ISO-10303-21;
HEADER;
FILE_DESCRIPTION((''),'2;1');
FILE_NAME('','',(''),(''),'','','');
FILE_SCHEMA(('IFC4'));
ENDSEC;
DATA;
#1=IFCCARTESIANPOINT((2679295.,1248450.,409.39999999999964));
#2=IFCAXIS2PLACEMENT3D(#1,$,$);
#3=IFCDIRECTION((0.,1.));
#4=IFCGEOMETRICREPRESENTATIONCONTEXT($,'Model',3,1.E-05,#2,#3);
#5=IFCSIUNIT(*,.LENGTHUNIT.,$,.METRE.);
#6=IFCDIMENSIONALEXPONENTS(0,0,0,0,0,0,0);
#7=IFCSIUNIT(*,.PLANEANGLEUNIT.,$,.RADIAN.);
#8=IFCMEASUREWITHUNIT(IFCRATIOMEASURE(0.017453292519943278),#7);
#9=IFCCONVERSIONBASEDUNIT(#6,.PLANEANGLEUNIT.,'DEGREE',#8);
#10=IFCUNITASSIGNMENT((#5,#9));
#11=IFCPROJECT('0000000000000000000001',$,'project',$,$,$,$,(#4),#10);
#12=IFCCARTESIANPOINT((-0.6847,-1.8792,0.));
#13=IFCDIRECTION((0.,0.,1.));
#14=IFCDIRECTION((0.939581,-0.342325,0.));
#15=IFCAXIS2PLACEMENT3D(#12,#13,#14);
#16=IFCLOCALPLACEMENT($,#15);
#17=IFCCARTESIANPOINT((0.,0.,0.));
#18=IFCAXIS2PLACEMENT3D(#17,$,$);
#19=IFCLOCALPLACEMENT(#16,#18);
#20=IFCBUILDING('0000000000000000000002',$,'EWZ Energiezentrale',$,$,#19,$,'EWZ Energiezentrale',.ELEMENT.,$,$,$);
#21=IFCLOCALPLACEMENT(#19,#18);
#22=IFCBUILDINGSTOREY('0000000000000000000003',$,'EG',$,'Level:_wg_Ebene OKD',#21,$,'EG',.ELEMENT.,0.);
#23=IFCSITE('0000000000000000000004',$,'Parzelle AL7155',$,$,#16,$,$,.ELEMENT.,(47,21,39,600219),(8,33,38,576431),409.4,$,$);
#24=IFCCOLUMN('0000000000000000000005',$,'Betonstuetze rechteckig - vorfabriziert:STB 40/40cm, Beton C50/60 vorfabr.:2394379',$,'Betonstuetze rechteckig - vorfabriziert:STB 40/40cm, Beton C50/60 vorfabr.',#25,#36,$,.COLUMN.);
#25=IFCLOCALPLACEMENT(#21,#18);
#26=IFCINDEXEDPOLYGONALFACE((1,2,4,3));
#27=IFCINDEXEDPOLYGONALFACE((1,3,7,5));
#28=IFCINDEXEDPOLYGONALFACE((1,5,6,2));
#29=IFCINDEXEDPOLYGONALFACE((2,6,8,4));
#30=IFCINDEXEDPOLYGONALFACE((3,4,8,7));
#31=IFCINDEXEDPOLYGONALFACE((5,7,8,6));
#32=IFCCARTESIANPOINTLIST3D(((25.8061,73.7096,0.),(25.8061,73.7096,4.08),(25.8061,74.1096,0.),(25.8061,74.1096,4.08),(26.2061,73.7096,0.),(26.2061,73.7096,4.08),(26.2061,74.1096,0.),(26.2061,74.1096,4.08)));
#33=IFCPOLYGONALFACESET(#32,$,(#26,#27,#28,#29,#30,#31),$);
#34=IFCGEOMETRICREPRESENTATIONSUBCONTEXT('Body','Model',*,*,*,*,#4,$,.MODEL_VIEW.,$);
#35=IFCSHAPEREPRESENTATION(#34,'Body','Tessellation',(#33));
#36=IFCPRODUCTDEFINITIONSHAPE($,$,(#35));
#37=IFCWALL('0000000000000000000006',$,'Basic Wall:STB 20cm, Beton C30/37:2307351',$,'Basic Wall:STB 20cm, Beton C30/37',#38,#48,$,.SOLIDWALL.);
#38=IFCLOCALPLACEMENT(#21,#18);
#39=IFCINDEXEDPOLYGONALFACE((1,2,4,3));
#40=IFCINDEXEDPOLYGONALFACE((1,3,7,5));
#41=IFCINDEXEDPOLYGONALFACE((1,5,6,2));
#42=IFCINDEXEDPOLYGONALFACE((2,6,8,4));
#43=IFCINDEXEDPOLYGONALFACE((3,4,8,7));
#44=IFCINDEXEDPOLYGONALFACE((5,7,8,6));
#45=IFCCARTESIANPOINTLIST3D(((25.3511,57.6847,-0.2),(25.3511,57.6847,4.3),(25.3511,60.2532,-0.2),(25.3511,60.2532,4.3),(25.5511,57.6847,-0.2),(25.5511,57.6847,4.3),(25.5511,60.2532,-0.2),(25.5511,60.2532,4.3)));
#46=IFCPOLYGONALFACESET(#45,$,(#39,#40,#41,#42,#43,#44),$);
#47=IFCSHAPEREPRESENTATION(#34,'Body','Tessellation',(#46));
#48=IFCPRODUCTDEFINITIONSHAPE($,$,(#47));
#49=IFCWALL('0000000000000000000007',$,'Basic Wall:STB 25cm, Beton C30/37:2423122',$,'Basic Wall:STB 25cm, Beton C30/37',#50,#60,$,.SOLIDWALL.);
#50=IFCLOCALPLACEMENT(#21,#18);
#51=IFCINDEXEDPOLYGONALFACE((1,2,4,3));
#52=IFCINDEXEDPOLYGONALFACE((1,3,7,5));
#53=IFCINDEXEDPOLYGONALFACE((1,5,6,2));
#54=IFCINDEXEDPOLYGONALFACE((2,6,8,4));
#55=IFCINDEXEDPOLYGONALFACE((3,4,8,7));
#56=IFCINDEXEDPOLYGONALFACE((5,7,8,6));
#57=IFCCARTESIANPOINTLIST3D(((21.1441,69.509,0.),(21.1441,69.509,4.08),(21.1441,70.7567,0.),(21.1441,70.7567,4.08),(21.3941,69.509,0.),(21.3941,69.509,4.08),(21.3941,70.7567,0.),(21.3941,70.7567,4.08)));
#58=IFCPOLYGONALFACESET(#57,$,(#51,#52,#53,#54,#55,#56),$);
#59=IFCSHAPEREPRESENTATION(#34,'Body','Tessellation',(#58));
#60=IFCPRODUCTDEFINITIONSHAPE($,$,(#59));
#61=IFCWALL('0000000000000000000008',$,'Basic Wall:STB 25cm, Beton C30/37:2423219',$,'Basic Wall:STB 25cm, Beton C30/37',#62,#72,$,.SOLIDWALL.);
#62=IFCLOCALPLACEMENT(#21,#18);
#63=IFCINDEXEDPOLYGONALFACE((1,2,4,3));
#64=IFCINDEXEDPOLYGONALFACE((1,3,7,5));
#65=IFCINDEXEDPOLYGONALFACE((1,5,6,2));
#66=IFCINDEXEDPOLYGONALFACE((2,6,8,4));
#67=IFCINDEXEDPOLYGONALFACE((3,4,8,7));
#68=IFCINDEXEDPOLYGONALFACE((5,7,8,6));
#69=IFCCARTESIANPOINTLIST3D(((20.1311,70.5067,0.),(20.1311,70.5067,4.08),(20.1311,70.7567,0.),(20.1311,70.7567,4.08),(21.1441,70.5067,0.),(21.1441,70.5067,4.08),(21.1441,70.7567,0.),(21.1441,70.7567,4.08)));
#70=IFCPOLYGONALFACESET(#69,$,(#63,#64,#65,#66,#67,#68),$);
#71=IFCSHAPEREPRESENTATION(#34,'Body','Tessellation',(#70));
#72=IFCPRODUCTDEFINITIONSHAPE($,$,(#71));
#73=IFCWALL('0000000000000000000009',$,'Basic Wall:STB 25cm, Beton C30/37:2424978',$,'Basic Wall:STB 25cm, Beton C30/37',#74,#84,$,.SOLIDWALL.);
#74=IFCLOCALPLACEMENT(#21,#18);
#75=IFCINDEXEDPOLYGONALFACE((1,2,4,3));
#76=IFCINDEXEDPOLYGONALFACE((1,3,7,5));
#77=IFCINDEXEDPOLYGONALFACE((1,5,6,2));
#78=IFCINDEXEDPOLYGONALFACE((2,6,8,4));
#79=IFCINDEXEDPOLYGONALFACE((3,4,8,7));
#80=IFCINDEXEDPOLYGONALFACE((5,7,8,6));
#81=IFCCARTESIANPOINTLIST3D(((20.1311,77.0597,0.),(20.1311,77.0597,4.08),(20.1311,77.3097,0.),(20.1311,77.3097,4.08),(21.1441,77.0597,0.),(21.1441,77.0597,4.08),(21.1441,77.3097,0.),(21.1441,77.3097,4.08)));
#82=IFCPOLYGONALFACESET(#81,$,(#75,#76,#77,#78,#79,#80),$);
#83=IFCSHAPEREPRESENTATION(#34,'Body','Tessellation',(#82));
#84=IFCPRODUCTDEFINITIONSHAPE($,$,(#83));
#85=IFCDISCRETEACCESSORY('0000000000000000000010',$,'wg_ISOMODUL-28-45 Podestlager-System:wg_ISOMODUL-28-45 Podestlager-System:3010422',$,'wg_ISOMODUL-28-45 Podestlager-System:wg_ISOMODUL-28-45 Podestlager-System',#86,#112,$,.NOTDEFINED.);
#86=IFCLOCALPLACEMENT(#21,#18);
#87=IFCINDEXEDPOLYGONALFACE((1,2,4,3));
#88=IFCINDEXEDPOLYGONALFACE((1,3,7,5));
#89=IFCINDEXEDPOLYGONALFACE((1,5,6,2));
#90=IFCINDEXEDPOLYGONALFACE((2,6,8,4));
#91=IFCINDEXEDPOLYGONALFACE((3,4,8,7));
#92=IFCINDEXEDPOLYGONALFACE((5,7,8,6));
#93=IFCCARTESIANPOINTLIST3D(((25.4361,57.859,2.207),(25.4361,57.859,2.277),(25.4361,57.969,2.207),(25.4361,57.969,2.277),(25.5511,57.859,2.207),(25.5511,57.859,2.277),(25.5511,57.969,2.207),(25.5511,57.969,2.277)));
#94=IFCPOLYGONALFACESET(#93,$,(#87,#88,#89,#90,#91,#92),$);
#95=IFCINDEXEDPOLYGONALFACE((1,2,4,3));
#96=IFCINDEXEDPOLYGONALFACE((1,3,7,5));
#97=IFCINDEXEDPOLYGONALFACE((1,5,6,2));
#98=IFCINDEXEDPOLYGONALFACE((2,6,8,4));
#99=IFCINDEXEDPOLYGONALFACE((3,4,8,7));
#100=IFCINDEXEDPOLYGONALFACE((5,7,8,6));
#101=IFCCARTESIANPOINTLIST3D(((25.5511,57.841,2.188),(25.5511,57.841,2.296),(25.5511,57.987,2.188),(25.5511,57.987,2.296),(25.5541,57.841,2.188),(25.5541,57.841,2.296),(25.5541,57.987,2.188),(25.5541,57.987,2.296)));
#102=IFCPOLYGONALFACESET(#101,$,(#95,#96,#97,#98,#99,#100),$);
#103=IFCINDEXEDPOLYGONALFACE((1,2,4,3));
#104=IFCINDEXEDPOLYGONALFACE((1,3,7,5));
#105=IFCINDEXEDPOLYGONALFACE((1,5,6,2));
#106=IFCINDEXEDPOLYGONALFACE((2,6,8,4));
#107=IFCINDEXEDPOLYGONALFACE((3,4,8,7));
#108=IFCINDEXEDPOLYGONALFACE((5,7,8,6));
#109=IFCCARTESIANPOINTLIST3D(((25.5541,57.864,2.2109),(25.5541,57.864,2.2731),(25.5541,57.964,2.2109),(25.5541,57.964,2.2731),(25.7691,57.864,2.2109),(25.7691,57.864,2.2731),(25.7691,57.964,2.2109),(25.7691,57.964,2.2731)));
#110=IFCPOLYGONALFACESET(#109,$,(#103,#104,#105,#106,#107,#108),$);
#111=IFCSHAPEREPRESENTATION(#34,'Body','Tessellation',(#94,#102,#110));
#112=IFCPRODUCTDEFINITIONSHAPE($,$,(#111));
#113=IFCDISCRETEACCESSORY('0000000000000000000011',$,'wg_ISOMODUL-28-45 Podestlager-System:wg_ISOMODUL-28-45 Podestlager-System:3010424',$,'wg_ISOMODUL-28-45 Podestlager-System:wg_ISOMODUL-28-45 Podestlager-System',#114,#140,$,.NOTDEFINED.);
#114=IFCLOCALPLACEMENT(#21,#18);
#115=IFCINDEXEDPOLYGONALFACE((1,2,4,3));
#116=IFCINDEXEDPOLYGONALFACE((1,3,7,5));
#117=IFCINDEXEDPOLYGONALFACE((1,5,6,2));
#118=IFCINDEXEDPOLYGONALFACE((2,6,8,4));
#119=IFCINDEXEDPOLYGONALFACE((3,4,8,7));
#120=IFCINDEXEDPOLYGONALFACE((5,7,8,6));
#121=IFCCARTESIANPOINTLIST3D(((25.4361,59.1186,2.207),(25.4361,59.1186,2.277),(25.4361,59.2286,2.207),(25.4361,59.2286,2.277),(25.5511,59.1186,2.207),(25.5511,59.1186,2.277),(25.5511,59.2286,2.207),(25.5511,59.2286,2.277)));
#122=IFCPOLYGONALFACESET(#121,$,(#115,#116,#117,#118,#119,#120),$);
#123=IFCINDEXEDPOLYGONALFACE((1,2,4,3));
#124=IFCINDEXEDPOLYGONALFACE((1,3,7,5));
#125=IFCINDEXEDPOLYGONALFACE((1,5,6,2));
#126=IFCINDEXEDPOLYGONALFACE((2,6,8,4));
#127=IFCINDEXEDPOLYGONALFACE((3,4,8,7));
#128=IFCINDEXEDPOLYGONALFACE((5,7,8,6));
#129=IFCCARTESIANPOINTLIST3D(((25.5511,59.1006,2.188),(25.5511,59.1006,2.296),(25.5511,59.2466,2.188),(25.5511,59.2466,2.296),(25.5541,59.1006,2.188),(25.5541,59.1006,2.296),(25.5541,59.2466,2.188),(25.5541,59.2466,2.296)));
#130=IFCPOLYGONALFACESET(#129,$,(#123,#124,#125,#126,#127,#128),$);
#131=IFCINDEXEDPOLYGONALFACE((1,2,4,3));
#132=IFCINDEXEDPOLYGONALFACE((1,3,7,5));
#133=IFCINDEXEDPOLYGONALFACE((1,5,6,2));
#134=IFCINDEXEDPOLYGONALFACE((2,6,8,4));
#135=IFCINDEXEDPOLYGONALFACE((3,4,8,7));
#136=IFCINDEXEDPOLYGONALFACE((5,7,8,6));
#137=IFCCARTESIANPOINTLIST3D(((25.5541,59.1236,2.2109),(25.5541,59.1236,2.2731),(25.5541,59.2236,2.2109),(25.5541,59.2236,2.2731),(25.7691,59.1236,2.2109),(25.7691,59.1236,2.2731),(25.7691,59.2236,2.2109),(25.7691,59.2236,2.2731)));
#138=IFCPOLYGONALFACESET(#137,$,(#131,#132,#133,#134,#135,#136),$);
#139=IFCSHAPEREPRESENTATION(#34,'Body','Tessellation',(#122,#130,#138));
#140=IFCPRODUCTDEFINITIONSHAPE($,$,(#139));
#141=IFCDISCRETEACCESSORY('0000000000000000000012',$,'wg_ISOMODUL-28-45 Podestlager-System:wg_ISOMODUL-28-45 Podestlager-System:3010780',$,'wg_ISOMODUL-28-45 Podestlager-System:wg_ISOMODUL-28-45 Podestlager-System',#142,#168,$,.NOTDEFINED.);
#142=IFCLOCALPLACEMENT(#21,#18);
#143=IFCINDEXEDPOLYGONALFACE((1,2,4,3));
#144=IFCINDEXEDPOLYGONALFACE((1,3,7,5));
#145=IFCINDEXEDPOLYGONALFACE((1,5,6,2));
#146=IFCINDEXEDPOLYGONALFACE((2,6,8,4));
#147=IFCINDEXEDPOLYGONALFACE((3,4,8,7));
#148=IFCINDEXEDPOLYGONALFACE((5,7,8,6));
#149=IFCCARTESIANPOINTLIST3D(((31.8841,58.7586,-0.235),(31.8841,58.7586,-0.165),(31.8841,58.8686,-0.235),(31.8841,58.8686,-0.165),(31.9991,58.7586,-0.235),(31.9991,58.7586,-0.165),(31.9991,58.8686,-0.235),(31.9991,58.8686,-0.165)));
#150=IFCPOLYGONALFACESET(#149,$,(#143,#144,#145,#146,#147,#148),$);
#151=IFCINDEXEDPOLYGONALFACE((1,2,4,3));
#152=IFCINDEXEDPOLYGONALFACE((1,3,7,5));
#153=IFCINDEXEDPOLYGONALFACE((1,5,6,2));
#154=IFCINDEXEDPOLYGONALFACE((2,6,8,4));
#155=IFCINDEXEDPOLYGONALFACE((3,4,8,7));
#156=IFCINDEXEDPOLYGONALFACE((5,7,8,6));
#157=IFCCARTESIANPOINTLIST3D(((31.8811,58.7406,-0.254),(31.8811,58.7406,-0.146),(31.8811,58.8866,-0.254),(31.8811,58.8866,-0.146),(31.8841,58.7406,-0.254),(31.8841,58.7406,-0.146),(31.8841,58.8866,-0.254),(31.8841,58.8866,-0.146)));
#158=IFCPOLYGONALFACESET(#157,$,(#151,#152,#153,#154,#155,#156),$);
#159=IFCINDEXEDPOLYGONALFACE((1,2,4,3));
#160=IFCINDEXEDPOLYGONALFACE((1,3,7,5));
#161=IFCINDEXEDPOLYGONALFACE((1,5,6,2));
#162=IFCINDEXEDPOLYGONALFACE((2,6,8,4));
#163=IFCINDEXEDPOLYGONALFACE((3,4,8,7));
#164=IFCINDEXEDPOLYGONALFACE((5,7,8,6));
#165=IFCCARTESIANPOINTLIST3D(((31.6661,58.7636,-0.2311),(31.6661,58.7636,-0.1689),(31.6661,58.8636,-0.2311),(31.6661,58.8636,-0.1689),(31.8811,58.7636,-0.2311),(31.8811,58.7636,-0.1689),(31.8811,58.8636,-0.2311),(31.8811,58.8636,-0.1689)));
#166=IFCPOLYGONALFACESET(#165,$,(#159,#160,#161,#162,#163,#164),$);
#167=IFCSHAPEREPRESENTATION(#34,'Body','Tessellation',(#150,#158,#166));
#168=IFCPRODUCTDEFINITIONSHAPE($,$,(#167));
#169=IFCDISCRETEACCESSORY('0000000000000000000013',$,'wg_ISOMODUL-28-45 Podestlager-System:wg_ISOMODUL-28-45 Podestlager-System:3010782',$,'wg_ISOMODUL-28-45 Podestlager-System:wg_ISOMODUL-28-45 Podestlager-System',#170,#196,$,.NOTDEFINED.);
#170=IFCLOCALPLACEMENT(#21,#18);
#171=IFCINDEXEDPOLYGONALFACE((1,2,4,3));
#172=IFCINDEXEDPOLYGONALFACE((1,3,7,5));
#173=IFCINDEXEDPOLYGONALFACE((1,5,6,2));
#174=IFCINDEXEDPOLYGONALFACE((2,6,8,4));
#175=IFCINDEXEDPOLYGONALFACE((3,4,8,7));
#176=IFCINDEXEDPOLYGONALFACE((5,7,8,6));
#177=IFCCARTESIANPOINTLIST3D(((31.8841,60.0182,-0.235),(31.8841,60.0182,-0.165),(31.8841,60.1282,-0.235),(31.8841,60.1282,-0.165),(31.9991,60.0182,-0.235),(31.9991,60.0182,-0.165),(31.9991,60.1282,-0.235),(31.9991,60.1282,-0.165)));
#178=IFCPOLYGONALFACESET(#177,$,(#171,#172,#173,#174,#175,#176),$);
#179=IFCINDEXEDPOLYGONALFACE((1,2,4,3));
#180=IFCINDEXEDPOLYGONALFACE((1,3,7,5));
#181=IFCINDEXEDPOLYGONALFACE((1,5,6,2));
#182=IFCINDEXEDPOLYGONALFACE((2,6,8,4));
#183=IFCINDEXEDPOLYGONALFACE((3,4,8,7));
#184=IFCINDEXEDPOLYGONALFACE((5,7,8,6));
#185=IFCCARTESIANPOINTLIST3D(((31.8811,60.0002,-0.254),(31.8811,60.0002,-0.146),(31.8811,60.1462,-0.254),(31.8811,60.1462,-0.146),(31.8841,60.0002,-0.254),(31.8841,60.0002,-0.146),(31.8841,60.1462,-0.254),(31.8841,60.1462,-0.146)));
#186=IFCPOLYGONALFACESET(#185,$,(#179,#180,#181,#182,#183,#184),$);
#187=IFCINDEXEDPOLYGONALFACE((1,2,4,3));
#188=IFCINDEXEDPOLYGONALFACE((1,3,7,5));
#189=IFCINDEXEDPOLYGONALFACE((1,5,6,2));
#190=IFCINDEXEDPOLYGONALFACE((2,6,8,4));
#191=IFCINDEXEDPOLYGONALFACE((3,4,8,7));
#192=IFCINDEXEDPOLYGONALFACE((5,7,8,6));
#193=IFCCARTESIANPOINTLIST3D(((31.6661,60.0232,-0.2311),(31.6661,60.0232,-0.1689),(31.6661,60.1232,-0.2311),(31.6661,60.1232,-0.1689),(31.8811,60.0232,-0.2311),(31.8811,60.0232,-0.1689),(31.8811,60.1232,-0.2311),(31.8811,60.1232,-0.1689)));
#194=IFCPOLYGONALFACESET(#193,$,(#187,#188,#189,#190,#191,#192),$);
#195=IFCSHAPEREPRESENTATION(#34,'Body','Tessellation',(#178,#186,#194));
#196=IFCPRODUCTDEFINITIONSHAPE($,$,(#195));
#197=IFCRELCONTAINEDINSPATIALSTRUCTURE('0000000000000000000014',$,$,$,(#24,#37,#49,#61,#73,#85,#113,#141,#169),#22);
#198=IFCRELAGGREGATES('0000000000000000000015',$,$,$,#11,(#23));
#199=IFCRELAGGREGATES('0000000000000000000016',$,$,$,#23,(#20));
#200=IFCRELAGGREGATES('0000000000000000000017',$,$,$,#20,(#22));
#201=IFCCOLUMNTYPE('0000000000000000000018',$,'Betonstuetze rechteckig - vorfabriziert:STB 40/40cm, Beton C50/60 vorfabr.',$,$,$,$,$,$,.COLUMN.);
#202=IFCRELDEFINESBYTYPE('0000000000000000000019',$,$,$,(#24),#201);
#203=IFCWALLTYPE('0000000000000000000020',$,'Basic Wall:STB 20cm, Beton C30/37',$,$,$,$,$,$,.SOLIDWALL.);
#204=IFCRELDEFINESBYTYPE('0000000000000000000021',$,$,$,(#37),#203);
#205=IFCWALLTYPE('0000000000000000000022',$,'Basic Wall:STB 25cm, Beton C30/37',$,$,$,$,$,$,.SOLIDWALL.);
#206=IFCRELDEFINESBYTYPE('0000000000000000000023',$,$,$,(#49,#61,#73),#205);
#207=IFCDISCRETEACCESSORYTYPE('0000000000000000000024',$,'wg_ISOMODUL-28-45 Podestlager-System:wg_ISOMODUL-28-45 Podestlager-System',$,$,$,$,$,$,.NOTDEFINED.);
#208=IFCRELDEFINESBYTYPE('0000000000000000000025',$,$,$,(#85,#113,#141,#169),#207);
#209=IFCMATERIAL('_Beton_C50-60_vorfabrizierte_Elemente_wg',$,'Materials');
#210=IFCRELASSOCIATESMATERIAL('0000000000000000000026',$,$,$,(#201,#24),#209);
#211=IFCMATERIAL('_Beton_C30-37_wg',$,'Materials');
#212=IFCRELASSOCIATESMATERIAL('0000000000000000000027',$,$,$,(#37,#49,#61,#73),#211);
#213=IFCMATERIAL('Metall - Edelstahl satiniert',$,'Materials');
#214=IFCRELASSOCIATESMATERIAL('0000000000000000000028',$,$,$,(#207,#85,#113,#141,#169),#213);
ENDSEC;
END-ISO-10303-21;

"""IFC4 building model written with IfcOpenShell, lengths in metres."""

from ifc_helpers import new_model, entity, si_unit, converted_unit, direction, frame, origin, place, context, subcontext, project, spatial, indexed_curve, outline, extrude, source, transform, mapped, material, type_object, type_shapes, element, save


model = new_model("IFC4")

# Units and contexts
model_context = context("Model", 3, precision=1e-05, world=frame((2679295.0, 1248450.0, 409.39999999999964)), true_north=direction((0.0, 1.0)))
body_context = subcontext(model_context, "Body", "Model", "MODEL_VIEW")
ifc_project = project(units=[si_unit("LENGTHUNIT", "METRE"), converted_unit("PLANEANGLEUNIT", "DEGREE", entity("IfcRatioMeasure", 0.017453292519943278), si_unit("PLANEANGLEUNIT", "RADIAN"), dimensions=[0, 0, 0, 0, 0, 0, 0])], contexts=[model_context])

# Site, building, storey
site_placement = place(None, frame((-0.6847, -1.8792, 0.0), z_axis=(0.0, 0.0, 1.0), x_axis=(0.939581, -0.342325, 0.0)))
site = spatial("IfcSite", under=ifc_project, at=site_placement, Name="Parzelle AL7155", CompositionType="ELEMENT", RefLatitude=(47, 21, 39, 600219), RefLongitude=(8, 33, 38, 576431), RefElevation=409.4)
building_placement = place(site_placement, origin())
building = spatial("IfcBuilding", under=site, at=building_placement, Name="EWZ Energiezentrale", LongName="EWZ Energiezentrale", CompositionType="ELEMENT")
storey_placement = place(building_placement, origin())
storey = spatial("IfcBuildingStorey", under=building, at=storey_placement, Name="EG", ObjectType="Level:_wg_Ebene OKD", LongName="EG", CompositionType="ELEMENT", Elevation=0.0)

# Column
ifc_material_1 = material(Name="_Beton_C50-60_vorfabrizierte_Elemente_wg", Category="Materials")
column_type = type_object("IfcColumnType", Name="Betonstuetze rechteckig - vorfabriziert:STB 40/40cm, Beton C50/60 vorfabr.", PredefinedType="COLUMN", material=ifc_material_1)
shared_shape_1 = source(origin(), body_context, "Body", "SweptSolid", [
    extrude(outline(indexed_curve([(-0.2, -0.2), (0.2, -0.2), (0.2, 0.2), (-0.2, 0.2), (-0.2, -0.2)], self_intersect=False)), frame((0.0, 0.0, 0.0), z_axis=(0.0, 0.0, 1.0), x_axis=(0.0, -1.0, 0.0)), (0.0, 0.0, 1.0), 4.08),
])
column_placement = place(storey_placement, frame((26.0061, 73.9096, 0.0)))
element("IfcColumn", 1, at=column_placement, inside=storey, type_object=column_type, material=ifc_material_1, Name="Betonstuetze rechteckig - vorfabriziert:STB 40/40cm, Beton C50/60 vorfabr.:2394379", ObjectType="Betonstuetze rechteckig - vorfabriziert:STB 40/40cm, Beton C50/60 vorfabr.", PredefinedType="COLUMN", context=body_context, shape_type="MappedRepresentation", body=[
    mapped(shared_shape_1, transform((0.0, 0.0, 0.0), scale=1.0)),
])

# Walls
ifc_material_2 = material(Name="_Beton_C30-37_wg", Category="Materials")
wall_type_1 = type_object("IfcWallType", Name="Basic Wall:STB 20cm, Beton C30/37", PredefinedType="SOLIDWALL")
wall_1_placement = place(storey_placement, frame((25.4511, 57.6847, -0.2), z_axis=(0.0, 0.0, 1.0), x_axis=(0.0, 1.0, 0.0)))
element("IfcWall", 2, at=wall_1_placement, inside=storey, type_object=wall_type_1, material=ifc_material_2, Name="Basic Wall:STB 20cm, Beton C30/37:2307351", ObjectType="Basic Wall:STB 20cm, Beton C30/37", PredefinedType="SOLIDWALL", context=body_context, shape_type="SweptSolid", body=[
    extrude(outline(indexed_curve([(2.5686, 0.1), (0.0, 0.1), (0.0, -0.1), (2.5686, -0.1), (2.5686, 0.1)], self_intersect=False)), origin(), (0.0, 0.0, 1.0), 4.5),
])
wall_type_2 = type_object("IfcWallType", Name="Basic Wall:STB 25cm, Beton C30/37", PredefinedType="SOLIDWALL")
wall_2_placement = place(storey_placement, frame((21.2691, 69.509, 0.0), z_axis=(0.0, 0.0, 1.0), x_axis=(0.0, 1.0, 0.0)))
element("IfcWall", 3, at=wall_2_placement, inside=storey, type_object=wall_type_2, material=ifc_material_2, Name="Basic Wall:STB 25cm, Beton C30/37:2423122", ObjectType="Basic Wall:STB 25cm, Beton C30/37", PredefinedType="SOLIDWALL", context=body_context, shape_type="SweptSolid", body=[
    extrude(outline(indexed_curve([(1.2476, 0.125), (0.0, 0.125), (0.0, -0.125), (1.2476, -0.125), (1.2476, 0.125)], self_intersect=False)), origin(), (0.0, 0.0, 1.0), 4.08),
])
wall_3_placement = place(storey_placement, frame((21.1441, 70.6317, 0.0), z_axis=(0.0, 0.0, 1.0), x_axis=(-1.0, 0.0, 0.0)))
element("IfcWall", 4, at=wall_3_placement, inside=storey, type_object=wall_type_2, material=ifc_material_2, Name="Basic Wall:STB 25cm, Beton C30/37:2423219", ObjectType="Basic Wall:STB 25cm, Beton C30/37", PredefinedType="SOLIDWALL", context=body_context, shape_type="SweptSolid", body=[
    extrude(outline(indexed_curve([(1.013, 0.125), (0.0, 0.125), (0.0, -0.125), (1.013, -0.125), (1.013, 0.125)], self_intersect=False)), origin(), (0.0, 0.0, 1.0), 4.08),
])
wall_4_placement = place(storey_placement, frame((21.1441, 77.1847, 0.0), z_axis=(0.0, 0.0, 1.0), x_axis=(-1.0, 0.0, 0.0)))
element("IfcWall", 5, at=wall_4_placement, inside=storey, type_object=wall_type_2, material=ifc_material_2, Name="Basic Wall:STB 25cm, Beton C30/37:2424978", ObjectType="Basic Wall:STB 25cm, Beton C30/37", PredefinedType="SOLIDWALL", context=body_context, shape_type="SweptSolid", body=[
    extrude(outline(indexed_curve([(1.013, 0.125), (0.0, 0.125), (0.0, -0.125), (1.013, -0.125), (1.013, 0.125)], self_intersect=False)), origin(), (0.0, 0.0, 1.0), 4.08),
])

# Discrete accessories
ifc_material_3 = material(Name="Metall - Edelstahl satiniert", Category="Materials")
discrete_accessory_type_1 = type_object("IfcDiscreteAccessoryType", Name="wg_ISOMODUL-28-45 Podestlager-System:wg_ISOMODUL-28-45 Podestlager-System", PredefinedType="NOTDEFINED", material=ifc_material_3)
shared_shape_2 = source(origin(), body_context, "Body", "SweptSolid", [
    extrude(outline(indexed_curve([(-0.055, -0.0575), (0.055, -0.0575), (0.055, 0.0575), (-0.055, 0.0575), (-0.055, -0.0575)], self_intersect=False)), frame((0.0, -0.0575, 0.0), z_axis=(0.0, 0.0, 1.0), x_axis=(-1.0, 0.0, 0.0)), (0.0, 0.0, 1.0), 0.07),
    extrude(outline(indexed_curve([(-0.073, -0.0015), (0.073, -0.0015), (0.073, 0.0015), (-0.073, 0.0015), (-0.073, -0.0015)], self_intersect=False)), frame((0.0, 0.0015, -0.019), z_axis=(0.0, 0.0, 1.0), x_axis=(-1.0, 0.0, 0.0)), (0.0, 0.0, 1.0), 0.108),
    extrude(outline(indexed_curve([(-0.05, -0.1075), (0.05, -0.1075), (0.05, 0.1075), (-0.05, 0.1075), (-0.05, -0.1075)], self_intersect=False)), frame((0.0, 0.1105, 0.0039), z_axis=(0.0, 0.0, 1.0), x_axis=(-1.0, 0.0, 0.0)), (0.0, 0.0, 1.0), 0.0621),
])
type_shapes(discrete_accessory_type_1, [shared_shape_2])
for number, where, z_axis, x_axis, name in (
    (6, (25.5511, 57.914, 2.207), (0.0, 0.0, 1.0), (0.0, -1.0, 0.0), "wg_ISOMODUL-28-45 Podestlager-System:wg_ISOMODUL-28-45 Podestlager-System:3010422"),
    (7, (25.5511, 59.1736, 2.207), (0.0, 0.0, 1.0), (0.0, -1.0, 0.0), "wg_ISOMODUL-28-45 Podestlager-System:wg_ISOMODUL-28-45 Podestlager-System:3010424"),
    (8, (31.8841, 58.8136, -0.235), (0.0, 0.0, 1.0), (0.0, 1.0, 0.0), "wg_ISOMODUL-28-45 Podestlager-System:wg_ISOMODUL-28-45 Podestlager-System:3010780"),
    (9, (31.8841, 60.0732, -0.235), (0.0, 0.0, 1.0), (0.0, 1.0, 0.0), "wg_ISOMODUL-28-45 Podestlager-System:wg_ISOMODUL-28-45 Podestlager-System:3010782"),
):
    element("IfcDiscreteAccessory", number, at=place(storey_placement, frame(where, z_axis=z_axis, x_axis=x_axis)), inside=storey, type_object=discrete_accessory_type_1, material=ifc_material_3, Name=name, ObjectType="wg_ISOMODUL-28-45 Podestlager-System:wg_ISOMODUL-28-45 Podestlager-System", PredefinedType="NOTDEFINED", context=body_context, shape_type="MappedRepresentation", body=[
        mapped(shared_shape_2, transform((0.0, 0.0, 0.0), scale=1.0)),
    ])

save(model, "model.ifc")
